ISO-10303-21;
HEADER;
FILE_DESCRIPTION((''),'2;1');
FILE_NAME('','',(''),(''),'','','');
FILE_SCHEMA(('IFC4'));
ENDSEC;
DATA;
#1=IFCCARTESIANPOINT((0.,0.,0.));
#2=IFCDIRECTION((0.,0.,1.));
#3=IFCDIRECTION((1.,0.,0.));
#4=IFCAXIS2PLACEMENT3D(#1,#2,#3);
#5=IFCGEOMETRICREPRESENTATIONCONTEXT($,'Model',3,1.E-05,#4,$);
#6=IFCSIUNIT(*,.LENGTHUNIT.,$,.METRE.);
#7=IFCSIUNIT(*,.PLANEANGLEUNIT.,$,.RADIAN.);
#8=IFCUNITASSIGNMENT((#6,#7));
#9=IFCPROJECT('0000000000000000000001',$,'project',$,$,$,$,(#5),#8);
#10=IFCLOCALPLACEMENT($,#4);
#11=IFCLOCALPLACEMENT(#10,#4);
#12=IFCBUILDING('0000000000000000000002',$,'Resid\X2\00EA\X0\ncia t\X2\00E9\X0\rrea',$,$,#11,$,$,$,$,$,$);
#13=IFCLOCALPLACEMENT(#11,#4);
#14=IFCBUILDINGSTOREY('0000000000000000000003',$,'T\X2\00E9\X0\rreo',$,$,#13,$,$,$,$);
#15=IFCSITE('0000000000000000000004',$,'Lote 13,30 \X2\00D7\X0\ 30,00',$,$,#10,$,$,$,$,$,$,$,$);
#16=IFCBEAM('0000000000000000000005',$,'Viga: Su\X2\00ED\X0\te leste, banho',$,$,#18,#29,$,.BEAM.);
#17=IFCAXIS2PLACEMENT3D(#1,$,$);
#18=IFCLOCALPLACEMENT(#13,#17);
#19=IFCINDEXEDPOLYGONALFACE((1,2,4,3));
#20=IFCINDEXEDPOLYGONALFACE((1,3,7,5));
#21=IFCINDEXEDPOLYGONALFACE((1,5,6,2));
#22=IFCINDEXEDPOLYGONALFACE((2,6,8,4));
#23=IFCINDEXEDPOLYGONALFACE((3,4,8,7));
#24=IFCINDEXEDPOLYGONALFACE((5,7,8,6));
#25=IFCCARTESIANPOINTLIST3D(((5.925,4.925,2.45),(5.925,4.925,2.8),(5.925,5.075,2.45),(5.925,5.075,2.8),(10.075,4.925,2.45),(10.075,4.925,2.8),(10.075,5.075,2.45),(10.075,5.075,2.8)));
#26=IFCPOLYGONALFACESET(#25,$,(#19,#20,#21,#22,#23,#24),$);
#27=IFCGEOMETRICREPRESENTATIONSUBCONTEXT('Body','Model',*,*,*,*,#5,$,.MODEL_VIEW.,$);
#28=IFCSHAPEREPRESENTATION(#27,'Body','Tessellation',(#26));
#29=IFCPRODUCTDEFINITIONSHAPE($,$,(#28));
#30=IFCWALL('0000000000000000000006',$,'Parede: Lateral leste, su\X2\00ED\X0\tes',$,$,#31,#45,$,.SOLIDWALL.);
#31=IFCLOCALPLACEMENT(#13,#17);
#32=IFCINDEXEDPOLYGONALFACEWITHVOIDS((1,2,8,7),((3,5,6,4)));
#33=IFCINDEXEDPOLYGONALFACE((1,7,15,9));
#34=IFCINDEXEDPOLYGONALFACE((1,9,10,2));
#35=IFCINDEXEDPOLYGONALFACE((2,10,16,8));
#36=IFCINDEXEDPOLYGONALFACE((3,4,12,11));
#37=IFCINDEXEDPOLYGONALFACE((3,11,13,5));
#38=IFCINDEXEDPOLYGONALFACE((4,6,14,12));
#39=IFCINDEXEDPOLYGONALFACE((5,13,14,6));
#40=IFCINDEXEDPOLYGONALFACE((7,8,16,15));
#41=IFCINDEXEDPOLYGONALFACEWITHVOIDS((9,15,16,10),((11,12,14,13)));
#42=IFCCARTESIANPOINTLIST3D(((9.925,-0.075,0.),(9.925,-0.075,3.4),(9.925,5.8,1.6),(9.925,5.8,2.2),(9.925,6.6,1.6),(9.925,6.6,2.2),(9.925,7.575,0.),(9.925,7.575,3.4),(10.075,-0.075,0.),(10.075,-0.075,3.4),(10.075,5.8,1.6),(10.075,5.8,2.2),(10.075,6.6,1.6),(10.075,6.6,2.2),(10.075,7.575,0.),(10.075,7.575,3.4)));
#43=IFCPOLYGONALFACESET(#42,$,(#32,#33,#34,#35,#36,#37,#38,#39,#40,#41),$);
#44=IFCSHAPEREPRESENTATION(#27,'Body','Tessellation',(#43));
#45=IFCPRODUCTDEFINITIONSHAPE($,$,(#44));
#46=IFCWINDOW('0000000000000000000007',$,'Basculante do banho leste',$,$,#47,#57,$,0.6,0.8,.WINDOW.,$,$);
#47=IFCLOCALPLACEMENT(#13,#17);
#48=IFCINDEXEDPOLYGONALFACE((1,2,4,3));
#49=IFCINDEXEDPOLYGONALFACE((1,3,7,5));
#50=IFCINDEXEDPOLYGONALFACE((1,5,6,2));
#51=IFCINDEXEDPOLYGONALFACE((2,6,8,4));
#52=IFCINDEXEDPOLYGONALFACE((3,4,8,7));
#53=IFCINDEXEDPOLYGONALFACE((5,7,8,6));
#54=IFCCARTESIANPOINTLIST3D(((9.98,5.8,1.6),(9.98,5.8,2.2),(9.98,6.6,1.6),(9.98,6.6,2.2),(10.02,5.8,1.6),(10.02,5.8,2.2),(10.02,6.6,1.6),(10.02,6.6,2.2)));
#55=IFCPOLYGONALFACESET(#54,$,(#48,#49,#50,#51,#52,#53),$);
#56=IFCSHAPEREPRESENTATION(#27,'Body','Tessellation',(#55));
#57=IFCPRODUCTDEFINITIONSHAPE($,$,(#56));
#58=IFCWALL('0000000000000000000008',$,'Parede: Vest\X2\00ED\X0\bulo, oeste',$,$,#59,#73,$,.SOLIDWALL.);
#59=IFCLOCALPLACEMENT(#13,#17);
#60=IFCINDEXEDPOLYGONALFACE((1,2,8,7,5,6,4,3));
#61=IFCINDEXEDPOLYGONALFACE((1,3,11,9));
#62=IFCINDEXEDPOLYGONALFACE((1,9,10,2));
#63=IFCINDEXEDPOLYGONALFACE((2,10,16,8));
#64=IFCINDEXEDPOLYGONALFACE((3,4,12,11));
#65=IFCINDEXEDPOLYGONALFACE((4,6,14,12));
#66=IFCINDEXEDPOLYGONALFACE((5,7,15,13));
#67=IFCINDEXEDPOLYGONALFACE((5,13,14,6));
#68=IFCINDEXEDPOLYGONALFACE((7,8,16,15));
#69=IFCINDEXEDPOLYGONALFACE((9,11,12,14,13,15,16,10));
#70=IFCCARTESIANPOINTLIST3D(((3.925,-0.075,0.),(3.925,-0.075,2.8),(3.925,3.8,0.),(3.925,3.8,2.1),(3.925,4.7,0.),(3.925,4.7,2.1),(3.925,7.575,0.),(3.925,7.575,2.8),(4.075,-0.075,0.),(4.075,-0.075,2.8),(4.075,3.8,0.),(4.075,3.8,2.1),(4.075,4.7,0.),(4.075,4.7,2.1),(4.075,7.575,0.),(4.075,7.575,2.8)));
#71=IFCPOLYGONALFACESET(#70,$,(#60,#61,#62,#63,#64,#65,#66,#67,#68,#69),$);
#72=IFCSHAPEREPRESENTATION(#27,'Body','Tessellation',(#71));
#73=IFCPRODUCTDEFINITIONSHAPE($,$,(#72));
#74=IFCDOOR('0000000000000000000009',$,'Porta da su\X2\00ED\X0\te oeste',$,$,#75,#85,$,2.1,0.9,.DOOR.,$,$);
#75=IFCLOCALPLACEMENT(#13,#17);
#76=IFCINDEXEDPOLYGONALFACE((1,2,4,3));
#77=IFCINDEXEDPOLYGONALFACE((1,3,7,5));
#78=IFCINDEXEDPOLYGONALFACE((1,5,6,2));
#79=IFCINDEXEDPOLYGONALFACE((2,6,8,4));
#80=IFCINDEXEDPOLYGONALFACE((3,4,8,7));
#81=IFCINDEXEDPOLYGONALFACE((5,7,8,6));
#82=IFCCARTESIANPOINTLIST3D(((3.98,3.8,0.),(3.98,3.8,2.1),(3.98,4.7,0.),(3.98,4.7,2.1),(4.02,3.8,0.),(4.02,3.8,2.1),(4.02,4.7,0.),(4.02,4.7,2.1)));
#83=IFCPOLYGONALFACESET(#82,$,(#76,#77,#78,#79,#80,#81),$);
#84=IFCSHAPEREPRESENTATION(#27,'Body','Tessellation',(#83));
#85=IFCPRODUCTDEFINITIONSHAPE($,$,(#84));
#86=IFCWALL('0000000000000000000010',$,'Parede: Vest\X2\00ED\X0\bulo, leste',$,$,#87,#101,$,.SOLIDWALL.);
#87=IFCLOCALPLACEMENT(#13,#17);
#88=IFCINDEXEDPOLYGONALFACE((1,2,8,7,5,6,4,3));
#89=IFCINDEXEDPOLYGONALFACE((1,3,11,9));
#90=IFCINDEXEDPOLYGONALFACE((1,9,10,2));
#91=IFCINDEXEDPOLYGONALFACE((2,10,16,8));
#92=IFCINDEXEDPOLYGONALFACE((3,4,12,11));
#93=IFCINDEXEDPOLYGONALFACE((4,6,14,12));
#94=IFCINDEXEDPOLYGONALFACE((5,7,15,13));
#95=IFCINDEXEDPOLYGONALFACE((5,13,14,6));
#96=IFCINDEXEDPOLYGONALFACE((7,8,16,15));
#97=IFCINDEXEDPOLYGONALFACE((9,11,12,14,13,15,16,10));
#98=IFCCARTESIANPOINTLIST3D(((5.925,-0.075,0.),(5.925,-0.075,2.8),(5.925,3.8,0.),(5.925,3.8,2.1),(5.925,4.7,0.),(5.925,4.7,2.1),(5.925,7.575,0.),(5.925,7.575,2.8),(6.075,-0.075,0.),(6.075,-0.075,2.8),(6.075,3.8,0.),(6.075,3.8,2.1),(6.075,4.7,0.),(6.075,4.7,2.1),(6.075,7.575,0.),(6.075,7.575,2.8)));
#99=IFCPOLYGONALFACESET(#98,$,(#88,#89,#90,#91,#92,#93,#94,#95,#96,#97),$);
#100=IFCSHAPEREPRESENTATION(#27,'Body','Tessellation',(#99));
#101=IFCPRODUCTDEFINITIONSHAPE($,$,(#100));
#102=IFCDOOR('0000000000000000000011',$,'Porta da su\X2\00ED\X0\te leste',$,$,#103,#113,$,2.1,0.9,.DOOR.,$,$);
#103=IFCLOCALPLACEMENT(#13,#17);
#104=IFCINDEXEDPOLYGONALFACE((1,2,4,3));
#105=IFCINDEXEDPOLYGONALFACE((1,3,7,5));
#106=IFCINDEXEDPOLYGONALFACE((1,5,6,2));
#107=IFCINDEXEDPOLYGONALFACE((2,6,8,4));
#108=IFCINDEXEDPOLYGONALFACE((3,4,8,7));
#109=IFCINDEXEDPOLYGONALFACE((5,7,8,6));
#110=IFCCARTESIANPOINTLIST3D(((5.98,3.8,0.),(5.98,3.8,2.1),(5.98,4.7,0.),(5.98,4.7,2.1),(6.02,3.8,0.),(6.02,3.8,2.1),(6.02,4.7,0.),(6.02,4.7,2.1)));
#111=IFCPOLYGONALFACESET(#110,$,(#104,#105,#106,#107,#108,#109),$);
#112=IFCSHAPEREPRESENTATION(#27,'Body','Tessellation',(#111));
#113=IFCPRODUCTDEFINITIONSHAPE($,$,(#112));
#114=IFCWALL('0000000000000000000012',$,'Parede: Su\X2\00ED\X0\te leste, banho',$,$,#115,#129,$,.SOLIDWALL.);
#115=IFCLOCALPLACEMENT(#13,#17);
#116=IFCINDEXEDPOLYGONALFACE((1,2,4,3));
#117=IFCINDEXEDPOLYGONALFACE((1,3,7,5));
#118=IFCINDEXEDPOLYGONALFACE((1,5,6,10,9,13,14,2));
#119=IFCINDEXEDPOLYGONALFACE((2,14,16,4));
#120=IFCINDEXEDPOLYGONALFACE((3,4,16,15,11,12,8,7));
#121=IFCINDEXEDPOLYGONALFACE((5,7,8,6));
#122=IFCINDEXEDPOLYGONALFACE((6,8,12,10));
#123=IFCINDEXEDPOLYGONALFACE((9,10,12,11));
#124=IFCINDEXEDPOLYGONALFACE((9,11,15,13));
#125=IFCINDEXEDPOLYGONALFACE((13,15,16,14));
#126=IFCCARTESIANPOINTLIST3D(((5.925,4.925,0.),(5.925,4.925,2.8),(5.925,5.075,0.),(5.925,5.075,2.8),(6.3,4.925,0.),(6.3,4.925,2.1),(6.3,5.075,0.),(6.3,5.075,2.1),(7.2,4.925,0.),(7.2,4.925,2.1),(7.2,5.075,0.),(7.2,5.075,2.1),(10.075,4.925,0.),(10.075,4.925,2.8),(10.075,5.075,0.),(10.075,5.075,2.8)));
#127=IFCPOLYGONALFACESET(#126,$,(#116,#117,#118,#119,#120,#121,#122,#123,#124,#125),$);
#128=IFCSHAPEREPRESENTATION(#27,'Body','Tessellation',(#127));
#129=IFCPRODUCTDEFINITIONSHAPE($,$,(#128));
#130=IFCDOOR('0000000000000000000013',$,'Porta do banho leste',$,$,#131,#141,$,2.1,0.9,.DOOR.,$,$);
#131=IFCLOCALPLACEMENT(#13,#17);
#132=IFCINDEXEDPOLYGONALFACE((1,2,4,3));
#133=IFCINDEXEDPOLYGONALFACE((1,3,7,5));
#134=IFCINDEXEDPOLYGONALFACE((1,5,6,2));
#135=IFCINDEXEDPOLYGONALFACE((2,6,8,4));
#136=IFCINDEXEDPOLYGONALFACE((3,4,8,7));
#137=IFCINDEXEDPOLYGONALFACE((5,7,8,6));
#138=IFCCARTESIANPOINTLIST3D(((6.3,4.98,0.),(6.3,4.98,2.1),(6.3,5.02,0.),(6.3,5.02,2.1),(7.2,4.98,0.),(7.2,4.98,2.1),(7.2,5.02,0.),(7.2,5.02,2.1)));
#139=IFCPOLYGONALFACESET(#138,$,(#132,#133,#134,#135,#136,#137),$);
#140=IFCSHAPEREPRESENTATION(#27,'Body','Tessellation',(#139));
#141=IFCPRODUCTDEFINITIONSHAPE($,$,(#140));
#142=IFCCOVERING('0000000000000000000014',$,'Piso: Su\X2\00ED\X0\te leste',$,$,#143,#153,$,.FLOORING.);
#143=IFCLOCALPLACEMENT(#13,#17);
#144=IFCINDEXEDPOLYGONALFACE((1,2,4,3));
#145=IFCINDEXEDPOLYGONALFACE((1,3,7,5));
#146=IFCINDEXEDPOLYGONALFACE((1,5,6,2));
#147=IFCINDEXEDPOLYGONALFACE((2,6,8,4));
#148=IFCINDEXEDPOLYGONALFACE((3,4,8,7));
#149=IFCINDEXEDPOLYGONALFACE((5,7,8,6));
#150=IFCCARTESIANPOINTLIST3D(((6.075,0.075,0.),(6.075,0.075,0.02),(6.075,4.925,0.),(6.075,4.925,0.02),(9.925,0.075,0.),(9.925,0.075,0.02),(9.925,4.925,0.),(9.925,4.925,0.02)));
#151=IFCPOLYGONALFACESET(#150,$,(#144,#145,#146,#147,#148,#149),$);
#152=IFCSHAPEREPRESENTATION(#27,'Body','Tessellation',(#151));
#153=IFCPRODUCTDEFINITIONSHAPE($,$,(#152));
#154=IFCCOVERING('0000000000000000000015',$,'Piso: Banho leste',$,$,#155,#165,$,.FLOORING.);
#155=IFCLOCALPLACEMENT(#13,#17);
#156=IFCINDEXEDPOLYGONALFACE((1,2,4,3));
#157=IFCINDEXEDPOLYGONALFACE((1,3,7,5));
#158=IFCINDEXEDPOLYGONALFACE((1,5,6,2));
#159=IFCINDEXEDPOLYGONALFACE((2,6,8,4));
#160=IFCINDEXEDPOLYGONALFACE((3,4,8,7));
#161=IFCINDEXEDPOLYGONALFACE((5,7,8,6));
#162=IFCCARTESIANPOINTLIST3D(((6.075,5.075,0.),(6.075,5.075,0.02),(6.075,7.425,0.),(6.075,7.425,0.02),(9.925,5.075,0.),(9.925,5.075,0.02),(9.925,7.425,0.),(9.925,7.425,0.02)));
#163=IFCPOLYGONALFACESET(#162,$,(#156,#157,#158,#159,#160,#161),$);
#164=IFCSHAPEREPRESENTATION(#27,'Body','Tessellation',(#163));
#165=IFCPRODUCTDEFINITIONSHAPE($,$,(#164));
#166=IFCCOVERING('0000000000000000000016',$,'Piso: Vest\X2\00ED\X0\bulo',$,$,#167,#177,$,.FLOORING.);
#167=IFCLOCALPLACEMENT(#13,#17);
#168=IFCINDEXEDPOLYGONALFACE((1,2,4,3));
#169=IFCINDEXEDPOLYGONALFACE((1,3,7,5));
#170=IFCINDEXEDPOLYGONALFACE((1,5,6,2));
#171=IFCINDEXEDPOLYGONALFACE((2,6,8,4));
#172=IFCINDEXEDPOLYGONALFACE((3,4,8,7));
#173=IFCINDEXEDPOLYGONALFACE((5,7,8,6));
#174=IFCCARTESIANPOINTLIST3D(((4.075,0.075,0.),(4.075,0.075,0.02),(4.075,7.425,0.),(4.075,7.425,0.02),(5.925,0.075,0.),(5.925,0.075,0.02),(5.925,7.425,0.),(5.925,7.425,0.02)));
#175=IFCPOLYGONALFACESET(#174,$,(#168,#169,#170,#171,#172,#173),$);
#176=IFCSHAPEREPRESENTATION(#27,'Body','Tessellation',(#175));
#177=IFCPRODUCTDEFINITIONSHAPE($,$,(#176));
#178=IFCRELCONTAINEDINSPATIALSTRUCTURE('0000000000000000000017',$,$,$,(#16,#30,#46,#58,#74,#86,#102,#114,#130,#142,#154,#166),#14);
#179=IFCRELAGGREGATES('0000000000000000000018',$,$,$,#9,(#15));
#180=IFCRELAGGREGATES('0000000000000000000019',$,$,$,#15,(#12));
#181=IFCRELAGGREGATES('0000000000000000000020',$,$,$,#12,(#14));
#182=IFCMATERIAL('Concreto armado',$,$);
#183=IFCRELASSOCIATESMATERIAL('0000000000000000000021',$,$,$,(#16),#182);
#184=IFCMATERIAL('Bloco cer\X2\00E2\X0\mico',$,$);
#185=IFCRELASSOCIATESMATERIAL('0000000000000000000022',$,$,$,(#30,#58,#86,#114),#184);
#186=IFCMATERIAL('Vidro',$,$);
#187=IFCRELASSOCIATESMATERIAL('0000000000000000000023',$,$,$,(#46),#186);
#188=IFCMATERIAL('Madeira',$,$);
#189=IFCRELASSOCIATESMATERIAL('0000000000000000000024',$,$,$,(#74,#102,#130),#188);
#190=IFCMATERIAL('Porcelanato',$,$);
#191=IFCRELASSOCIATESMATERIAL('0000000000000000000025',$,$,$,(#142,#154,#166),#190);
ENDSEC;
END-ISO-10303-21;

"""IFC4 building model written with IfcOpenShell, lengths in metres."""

from ifc_helpers import new_model, si_unit, frame, origin_with_axes, place, context, subcontext, project, spatial, line, indexed_curve, outline, extrude, material, element, fill, save


model = new_model("IFC4")

# Units and contexts
model_context = context("Model", 3, precision=1e-05, world=origin_with_axes())
body_context = subcontext(model_context, "Body", "Model", "MODEL_VIEW")
ifc_project = project(units=[si_unit("LENGTHUNIT", "METRE"), si_unit("PLANEANGLEUNIT", "RADIAN")], contexts=[model_context])

# Site, building, storey
site_placement = place(None, origin_with_axes())
site = spatial("IfcSite", under=ifc_project, at=site_placement, Name="Lote 13,30 × 30,00")
building_placement = place(site_placement, origin_with_axes())
building = spatial("IfcBuilding", under=site, at=building_placement, Name="Residência térrea")
storey_placement = place(building_placement, origin_with_axes())
storey = spatial("IfcBuildingStorey", under=building, at=storey_placement, Name="Térreo")

# Shared definitions
ifc_material_1 = material(Name="Concreto armado")

# Beam
beam_1_placement = place(storey_placement, frame((5.925, 4.925, 2.45), z_axis=(0.0, 0.0, 1.0), x_axis=(1.0, 0.0, 0.0)))
element("IfcBeam", 1, at=beam_1_placement, inside=storey, material=ifc_material_1, Name="Viga: Suíte leste, banho", PredefinedType="BEAM", context=body_context, shape_type="SweptSolid", body=[
    extrude(outline(indexed_curve([(0.0, 0.0), (4.15, 0.0), (4.15, 0.15), (0.0, 0.15)], segments=[line(1, 2, 3, 4, 1)])), origin_with_axes(), (0.0, 0.0, 1.0), 0.35),
])

# Wall, opening, window
ifc_material_2 = material(Name="Bloco cerâmico")
wall_1_placement = place(storey_placement, frame((9.925, -0.075, 0.0), z_axis=(0.0, 0.0, 1.0), x_axis=(1.0, 0.0, 0.0)))
wall_1 = element("IfcWall", 2, at=wall_1_placement, inside=storey, material=ifc_material_2, Name="Parede: Lateral leste, suítes", PredefinedType="SOLIDWALL", context=body_context, shape_type="SweptSolid", body=[
    extrude(outline(indexed_curve([(0.0, 0.0), (0.15, 0.0), (0.15, 7.65), (0.0, 7.65)], segments=[line(1, 2, 3, 4, 1)])), origin_with_axes(), (0.0, 0.0, 1.0), 3.4),
])
opening_1_placement = place(wall_1_placement, frame((-0.05, 5.875, 1.6), z_axis=(0.0, 0.0, 1.0), x_axis=(1.0, 0.0, 0.0)))
opening_1 = element("IfcOpeningElement", 3, at=opening_1_placement, cuts=wall_1, material=ifc_material_1, PredefinedType="OPENING", context=body_context, shape_type="SweptSolid", body=[
    extrude(outline(indexed_curve([(0.0, 0.0), (0.25, 0.0), (0.25, 0.8), (0.0, 0.8)], segments=[line(1, 2, 3, 4, 1)])), origin_with_axes(), (0.0, 0.0, 1.0), 0.6),
])
ifc_material_3 = material(Name="Vidro")
window_placement = place(storey_placement, frame((9.98, 5.8, 1.6), z_axis=(0.0, 0.0, 1.0), x_axis=(1.0, 0.0, 0.0)))
window = element("IfcWindow", 4, at=window_placement, inside=storey, material=ifc_material_3, Name="Basculante do banho leste", OverallHeight=0.6, OverallWidth=0.8, PredefinedType="WINDOW", context=body_context, shape_type="SweptSolid", body=[
    extrude(outline(indexed_curve([(0.0, 0.0), (0.04, 0.0), (0.04, 0.8), (0.0, 0.8)], segments=[line(1, 2, 3, 4, 1)])), origin_with_axes(), (0.0, 0.0, 1.0), 0.6),
])
fill(opening_1, window)

# Walls, openings, doors
wall_2_placement = place(storey_placement, frame((3.925, -0.075, 0.0), z_axis=(0.0, 0.0, 1.0), x_axis=(1.0, 0.0, 0.0)))
wall_2 = element("IfcWall", 5, at=wall_2_placement, inside=storey, material=ifc_material_2, Name="Parede: Vestíbulo, oeste", PredefinedType="SOLIDWALL", context=body_context, shape_type="SweptSolid", body=[
    extrude(outline(indexed_curve([(0.0, 0.0), (0.15, 0.0), (0.15, 7.65), (0.0, 7.65)], segments=[line(1, 2, 3, 4, 1)])), origin_with_axes(), (0.0, 0.0, 1.0), 2.8),
])
opening_2_placement = place(wall_2_placement, frame((-0.05, 3.875, 0.0), z_axis=(0.0, 0.0, 1.0), x_axis=(1.0, 0.0, 0.0)))
opening_2 = element("IfcOpeningElement", 6, at=opening_2_placement, cuts=wall_2, material=ifc_material_1, PredefinedType="OPENING", context=body_context, shape_type="SweptSolid", body=[
    extrude(outline(indexed_curve([(0.0, 0.0), (0.25, 0.0), (0.25, 0.9), (0.0, 0.9)], segments=[line(1, 2, 3, 4, 1)])), origin_with_axes(), (0.0, 0.0, 1.0), 2.1),
])
ifc_material_4 = material(Name="Madeira")
door_1_placement = place(storey_placement, frame((3.98, 3.8, 0.0), z_axis=(0.0, 0.0, 1.0), x_axis=(1.0, 0.0, 0.0)))
door_1 = element("IfcDoor", 7, at=door_1_placement, inside=storey, material=ifc_material_4, Name="Porta da suíte oeste", OverallHeight=2.1, OverallWidth=0.9, PredefinedType="DOOR", context=body_context, shape_type="SweptSolid", body=[
    extrude(outline(indexed_curve([(0.0, 0.0), (0.04, 0.0), (0.04, 0.9), (0.0, 0.9)], segments=[line(1, 2, 3, 4, 1)])), origin_with_axes(), (0.0, 0.0, 1.0), 2.1),
])
fill(opening_2, door_1)
wall_3_placement = place(storey_placement, frame((5.925, -0.075, 0.0), z_axis=(0.0, 0.0, 1.0), x_axis=(1.0, 0.0, 0.0)))
wall_3 = element("IfcWall", 8, at=wall_3_placement, inside=storey, material=ifc_material_2, Name="Parede: Vestíbulo, leste", PredefinedType="SOLIDWALL", context=body_context, shape_type="SweptSolid", body=[
    extrude(outline(indexed_curve([(0.0, 0.0), (0.15, 0.0), (0.15, 7.65), (0.0, 7.65)], segments=[line(1, 2, 3, 4, 1)])), origin_with_axes(), (0.0, 0.0, 1.0), 2.8),
])
opening_3_placement = place(wall_3_placement, frame((-0.05, 3.875, 0.0), z_axis=(0.0, 0.0, 1.0), x_axis=(1.0, 0.0, 0.0)))
opening_3 = element("IfcOpeningElement", 9, at=opening_3_placement, cuts=wall_3, material=ifc_material_1, PredefinedType="OPENING", context=body_context, shape_type="SweptSolid", body=[
    extrude(outline(indexed_curve([(0.0, 0.0), (0.25, 0.0), (0.25, 0.9), (0.0, 0.9)], segments=[line(1, 2, 3, 4, 1)])), origin_with_axes(), (0.0, 0.0, 1.0), 2.1),
])
door_2_placement = place(storey_placement, frame((5.98, 3.8, 0.0), z_axis=(0.0, 0.0, 1.0), x_axis=(1.0, 0.0, 0.0)))
door_2 = element("IfcDoor", 10, at=door_2_placement, inside=storey, material=ifc_material_4, Name="Porta da suíte leste", OverallHeight=2.1, OverallWidth=0.9, PredefinedType="DOOR", context=body_context, shape_type="SweptSolid", body=[
    extrude(outline(indexed_curve([(0.0, 0.0), (0.04, 0.0), (0.04, 0.9), (0.0, 0.9)], segments=[line(1, 2, 3, 4, 1)])), origin_with_axes(), (0.0, 0.0, 1.0), 2.1),
])
fill(opening_3, door_2)
wall_4_placement = place(storey_placement, frame((5.925, 4.925, 0.0), z_axis=(0.0, 0.0, 1.0), x_axis=(1.0, 0.0, 0.0)))
wall_4 = element("IfcWall", 11, at=wall_4_placement, inside=storey, material=ifc_material_2, Name="Parede: Suíte leste, banho", PredefinedType="SOLIDWALL", context=body_context, shape_type="SweptSolid", body=[
    extrude(outline(indexed_curve([(0.0, 0.0), (4.15, 0.0), (4.15, 0.15), (0.0, 0.15)], segments=[line(1, 2, 3, 4, 1)])), origin_with_axes(), (0.0, 0.0, 1.0), 2.8),
])
opening_4_placement = place(wall_4_placement, frame((0.375, -0.05, 0.0), z_axis=(0.0, 0.0, 1.0), x_axis=(1.0, 0.0, 0.0)))
opening_4 = element("IfcOpeningElement", 12, at=opening_4_placement, cuts=wall_4, material=ifc_material_1, PredefinedType="OPENING", context=body_context, shape_type="SweptSolid", body=[
    extrude(outline(indexed_curve([(0.0, 0.0), (0.9, 0.0), (0.9, 0.25), (0.0, 0.25)], segments=[line(1, 2, 3, 4, 1)])), origin_with_axes(), (0.0, 0.0, 1.0), 2.1),
])
door_3_placement = place(storey_placement, frame((6.3, 4.98, 0.0), z_axis=(0.0, 0.0, 1.0), x_axis=(1.0, 0.0, 0.0)))
door_3 = element("IfcDoor", 13, at=door_3_placement, inside=storey, material=ifc_material_4, Name="Porta do banho leste", OverallHeight=2.1, OverallWidth=0.9, PredefinedType="DOOR", context=body_context, shape_type="SweptSolid", body=[
    extrude(outline(indexed_curve([(0.0, 0.0), (0.9, 0.0), (0.9, 0.04), (0.0, 0.04)], segments=[line(1, 2, 3, 4, 1)])), origin_with_axes(), (0.0, 0.0, 1.0), 2.1),
])
fill(opening_4, door_3)

# Coverings
ifc_material_5 = material(Name="Porcelanato")
covering_1_placement = place(storey_placement, frame((6.075, 0.075, 0.0), z_axis=(0.0, 0.0, 1.0), x_axis=(1.0, 0.0, 0.0)))
element("IfcCovering", 14, at=covering_1_placement, inside=storey, material=ifc_material_5, Name="Piso: Suíte leste", PredefinedType="FLOORING", context=body_context, shape_type="SweptSolid", body=[
    extrude(outline(indexed_curve([(0.0, 0.0), (3.85, 0.0), (3.85, 4.85), (0.0, 4.85)], segments=[line(1, 2, 3, 4, 1)])), origin_with_axes(), (0.0, 0.0, 1.0), 0.02),
])
covering_2_placement = place(storey_placement, frame((6.075, 5.075, 0.0), z_axis=(0.0, 0.0, 1.0), x_axis=(1.0, 0.0, 0.0)))
element("IfcCovering", 15, at=covering_2_placement, inside=storey, material=ifc_material_5, Name="Piso: Banho leste", PredefinedType="FLOORING", context=body_context, shape_type="SweptSolid", body=[
    extrude(outline(indexed_curve([(0.0, 0.0), (3.85, 0.0), (3.85, 2.35), (0.0, 2.35)], segments=[line(1, 2, 3, 4, 1)])), origin_with_axes(), (0.0, 0.0, 1.0), 0.02),
])
covering_3_placement = place(storey_placement, frame((4.075, 0.075, 0.0), z_axis=(0.0, 0.0, 1.0), x_axis=(1.0, 0.0, 0.0)))
element("IfcCovering", 16, at=covering_3_placement, inside=storey, material=ifc_material_5, Name="Piso: Vestíbulo", PredefinedType="FLOORING", context=body_context, shape_type="SweptSolid", body=[
    extrude(outline(indexed_curve([(0.0, 0.0), (1.85, 0.0), (1.85, 7.35), (0.0, 7.35)], segments=[line(1, 2, 3, 4, 1)])), origin_with_axes(), (0.0, 0.0, 1.0), 0.02),
])

save(model, "model.ifc")
